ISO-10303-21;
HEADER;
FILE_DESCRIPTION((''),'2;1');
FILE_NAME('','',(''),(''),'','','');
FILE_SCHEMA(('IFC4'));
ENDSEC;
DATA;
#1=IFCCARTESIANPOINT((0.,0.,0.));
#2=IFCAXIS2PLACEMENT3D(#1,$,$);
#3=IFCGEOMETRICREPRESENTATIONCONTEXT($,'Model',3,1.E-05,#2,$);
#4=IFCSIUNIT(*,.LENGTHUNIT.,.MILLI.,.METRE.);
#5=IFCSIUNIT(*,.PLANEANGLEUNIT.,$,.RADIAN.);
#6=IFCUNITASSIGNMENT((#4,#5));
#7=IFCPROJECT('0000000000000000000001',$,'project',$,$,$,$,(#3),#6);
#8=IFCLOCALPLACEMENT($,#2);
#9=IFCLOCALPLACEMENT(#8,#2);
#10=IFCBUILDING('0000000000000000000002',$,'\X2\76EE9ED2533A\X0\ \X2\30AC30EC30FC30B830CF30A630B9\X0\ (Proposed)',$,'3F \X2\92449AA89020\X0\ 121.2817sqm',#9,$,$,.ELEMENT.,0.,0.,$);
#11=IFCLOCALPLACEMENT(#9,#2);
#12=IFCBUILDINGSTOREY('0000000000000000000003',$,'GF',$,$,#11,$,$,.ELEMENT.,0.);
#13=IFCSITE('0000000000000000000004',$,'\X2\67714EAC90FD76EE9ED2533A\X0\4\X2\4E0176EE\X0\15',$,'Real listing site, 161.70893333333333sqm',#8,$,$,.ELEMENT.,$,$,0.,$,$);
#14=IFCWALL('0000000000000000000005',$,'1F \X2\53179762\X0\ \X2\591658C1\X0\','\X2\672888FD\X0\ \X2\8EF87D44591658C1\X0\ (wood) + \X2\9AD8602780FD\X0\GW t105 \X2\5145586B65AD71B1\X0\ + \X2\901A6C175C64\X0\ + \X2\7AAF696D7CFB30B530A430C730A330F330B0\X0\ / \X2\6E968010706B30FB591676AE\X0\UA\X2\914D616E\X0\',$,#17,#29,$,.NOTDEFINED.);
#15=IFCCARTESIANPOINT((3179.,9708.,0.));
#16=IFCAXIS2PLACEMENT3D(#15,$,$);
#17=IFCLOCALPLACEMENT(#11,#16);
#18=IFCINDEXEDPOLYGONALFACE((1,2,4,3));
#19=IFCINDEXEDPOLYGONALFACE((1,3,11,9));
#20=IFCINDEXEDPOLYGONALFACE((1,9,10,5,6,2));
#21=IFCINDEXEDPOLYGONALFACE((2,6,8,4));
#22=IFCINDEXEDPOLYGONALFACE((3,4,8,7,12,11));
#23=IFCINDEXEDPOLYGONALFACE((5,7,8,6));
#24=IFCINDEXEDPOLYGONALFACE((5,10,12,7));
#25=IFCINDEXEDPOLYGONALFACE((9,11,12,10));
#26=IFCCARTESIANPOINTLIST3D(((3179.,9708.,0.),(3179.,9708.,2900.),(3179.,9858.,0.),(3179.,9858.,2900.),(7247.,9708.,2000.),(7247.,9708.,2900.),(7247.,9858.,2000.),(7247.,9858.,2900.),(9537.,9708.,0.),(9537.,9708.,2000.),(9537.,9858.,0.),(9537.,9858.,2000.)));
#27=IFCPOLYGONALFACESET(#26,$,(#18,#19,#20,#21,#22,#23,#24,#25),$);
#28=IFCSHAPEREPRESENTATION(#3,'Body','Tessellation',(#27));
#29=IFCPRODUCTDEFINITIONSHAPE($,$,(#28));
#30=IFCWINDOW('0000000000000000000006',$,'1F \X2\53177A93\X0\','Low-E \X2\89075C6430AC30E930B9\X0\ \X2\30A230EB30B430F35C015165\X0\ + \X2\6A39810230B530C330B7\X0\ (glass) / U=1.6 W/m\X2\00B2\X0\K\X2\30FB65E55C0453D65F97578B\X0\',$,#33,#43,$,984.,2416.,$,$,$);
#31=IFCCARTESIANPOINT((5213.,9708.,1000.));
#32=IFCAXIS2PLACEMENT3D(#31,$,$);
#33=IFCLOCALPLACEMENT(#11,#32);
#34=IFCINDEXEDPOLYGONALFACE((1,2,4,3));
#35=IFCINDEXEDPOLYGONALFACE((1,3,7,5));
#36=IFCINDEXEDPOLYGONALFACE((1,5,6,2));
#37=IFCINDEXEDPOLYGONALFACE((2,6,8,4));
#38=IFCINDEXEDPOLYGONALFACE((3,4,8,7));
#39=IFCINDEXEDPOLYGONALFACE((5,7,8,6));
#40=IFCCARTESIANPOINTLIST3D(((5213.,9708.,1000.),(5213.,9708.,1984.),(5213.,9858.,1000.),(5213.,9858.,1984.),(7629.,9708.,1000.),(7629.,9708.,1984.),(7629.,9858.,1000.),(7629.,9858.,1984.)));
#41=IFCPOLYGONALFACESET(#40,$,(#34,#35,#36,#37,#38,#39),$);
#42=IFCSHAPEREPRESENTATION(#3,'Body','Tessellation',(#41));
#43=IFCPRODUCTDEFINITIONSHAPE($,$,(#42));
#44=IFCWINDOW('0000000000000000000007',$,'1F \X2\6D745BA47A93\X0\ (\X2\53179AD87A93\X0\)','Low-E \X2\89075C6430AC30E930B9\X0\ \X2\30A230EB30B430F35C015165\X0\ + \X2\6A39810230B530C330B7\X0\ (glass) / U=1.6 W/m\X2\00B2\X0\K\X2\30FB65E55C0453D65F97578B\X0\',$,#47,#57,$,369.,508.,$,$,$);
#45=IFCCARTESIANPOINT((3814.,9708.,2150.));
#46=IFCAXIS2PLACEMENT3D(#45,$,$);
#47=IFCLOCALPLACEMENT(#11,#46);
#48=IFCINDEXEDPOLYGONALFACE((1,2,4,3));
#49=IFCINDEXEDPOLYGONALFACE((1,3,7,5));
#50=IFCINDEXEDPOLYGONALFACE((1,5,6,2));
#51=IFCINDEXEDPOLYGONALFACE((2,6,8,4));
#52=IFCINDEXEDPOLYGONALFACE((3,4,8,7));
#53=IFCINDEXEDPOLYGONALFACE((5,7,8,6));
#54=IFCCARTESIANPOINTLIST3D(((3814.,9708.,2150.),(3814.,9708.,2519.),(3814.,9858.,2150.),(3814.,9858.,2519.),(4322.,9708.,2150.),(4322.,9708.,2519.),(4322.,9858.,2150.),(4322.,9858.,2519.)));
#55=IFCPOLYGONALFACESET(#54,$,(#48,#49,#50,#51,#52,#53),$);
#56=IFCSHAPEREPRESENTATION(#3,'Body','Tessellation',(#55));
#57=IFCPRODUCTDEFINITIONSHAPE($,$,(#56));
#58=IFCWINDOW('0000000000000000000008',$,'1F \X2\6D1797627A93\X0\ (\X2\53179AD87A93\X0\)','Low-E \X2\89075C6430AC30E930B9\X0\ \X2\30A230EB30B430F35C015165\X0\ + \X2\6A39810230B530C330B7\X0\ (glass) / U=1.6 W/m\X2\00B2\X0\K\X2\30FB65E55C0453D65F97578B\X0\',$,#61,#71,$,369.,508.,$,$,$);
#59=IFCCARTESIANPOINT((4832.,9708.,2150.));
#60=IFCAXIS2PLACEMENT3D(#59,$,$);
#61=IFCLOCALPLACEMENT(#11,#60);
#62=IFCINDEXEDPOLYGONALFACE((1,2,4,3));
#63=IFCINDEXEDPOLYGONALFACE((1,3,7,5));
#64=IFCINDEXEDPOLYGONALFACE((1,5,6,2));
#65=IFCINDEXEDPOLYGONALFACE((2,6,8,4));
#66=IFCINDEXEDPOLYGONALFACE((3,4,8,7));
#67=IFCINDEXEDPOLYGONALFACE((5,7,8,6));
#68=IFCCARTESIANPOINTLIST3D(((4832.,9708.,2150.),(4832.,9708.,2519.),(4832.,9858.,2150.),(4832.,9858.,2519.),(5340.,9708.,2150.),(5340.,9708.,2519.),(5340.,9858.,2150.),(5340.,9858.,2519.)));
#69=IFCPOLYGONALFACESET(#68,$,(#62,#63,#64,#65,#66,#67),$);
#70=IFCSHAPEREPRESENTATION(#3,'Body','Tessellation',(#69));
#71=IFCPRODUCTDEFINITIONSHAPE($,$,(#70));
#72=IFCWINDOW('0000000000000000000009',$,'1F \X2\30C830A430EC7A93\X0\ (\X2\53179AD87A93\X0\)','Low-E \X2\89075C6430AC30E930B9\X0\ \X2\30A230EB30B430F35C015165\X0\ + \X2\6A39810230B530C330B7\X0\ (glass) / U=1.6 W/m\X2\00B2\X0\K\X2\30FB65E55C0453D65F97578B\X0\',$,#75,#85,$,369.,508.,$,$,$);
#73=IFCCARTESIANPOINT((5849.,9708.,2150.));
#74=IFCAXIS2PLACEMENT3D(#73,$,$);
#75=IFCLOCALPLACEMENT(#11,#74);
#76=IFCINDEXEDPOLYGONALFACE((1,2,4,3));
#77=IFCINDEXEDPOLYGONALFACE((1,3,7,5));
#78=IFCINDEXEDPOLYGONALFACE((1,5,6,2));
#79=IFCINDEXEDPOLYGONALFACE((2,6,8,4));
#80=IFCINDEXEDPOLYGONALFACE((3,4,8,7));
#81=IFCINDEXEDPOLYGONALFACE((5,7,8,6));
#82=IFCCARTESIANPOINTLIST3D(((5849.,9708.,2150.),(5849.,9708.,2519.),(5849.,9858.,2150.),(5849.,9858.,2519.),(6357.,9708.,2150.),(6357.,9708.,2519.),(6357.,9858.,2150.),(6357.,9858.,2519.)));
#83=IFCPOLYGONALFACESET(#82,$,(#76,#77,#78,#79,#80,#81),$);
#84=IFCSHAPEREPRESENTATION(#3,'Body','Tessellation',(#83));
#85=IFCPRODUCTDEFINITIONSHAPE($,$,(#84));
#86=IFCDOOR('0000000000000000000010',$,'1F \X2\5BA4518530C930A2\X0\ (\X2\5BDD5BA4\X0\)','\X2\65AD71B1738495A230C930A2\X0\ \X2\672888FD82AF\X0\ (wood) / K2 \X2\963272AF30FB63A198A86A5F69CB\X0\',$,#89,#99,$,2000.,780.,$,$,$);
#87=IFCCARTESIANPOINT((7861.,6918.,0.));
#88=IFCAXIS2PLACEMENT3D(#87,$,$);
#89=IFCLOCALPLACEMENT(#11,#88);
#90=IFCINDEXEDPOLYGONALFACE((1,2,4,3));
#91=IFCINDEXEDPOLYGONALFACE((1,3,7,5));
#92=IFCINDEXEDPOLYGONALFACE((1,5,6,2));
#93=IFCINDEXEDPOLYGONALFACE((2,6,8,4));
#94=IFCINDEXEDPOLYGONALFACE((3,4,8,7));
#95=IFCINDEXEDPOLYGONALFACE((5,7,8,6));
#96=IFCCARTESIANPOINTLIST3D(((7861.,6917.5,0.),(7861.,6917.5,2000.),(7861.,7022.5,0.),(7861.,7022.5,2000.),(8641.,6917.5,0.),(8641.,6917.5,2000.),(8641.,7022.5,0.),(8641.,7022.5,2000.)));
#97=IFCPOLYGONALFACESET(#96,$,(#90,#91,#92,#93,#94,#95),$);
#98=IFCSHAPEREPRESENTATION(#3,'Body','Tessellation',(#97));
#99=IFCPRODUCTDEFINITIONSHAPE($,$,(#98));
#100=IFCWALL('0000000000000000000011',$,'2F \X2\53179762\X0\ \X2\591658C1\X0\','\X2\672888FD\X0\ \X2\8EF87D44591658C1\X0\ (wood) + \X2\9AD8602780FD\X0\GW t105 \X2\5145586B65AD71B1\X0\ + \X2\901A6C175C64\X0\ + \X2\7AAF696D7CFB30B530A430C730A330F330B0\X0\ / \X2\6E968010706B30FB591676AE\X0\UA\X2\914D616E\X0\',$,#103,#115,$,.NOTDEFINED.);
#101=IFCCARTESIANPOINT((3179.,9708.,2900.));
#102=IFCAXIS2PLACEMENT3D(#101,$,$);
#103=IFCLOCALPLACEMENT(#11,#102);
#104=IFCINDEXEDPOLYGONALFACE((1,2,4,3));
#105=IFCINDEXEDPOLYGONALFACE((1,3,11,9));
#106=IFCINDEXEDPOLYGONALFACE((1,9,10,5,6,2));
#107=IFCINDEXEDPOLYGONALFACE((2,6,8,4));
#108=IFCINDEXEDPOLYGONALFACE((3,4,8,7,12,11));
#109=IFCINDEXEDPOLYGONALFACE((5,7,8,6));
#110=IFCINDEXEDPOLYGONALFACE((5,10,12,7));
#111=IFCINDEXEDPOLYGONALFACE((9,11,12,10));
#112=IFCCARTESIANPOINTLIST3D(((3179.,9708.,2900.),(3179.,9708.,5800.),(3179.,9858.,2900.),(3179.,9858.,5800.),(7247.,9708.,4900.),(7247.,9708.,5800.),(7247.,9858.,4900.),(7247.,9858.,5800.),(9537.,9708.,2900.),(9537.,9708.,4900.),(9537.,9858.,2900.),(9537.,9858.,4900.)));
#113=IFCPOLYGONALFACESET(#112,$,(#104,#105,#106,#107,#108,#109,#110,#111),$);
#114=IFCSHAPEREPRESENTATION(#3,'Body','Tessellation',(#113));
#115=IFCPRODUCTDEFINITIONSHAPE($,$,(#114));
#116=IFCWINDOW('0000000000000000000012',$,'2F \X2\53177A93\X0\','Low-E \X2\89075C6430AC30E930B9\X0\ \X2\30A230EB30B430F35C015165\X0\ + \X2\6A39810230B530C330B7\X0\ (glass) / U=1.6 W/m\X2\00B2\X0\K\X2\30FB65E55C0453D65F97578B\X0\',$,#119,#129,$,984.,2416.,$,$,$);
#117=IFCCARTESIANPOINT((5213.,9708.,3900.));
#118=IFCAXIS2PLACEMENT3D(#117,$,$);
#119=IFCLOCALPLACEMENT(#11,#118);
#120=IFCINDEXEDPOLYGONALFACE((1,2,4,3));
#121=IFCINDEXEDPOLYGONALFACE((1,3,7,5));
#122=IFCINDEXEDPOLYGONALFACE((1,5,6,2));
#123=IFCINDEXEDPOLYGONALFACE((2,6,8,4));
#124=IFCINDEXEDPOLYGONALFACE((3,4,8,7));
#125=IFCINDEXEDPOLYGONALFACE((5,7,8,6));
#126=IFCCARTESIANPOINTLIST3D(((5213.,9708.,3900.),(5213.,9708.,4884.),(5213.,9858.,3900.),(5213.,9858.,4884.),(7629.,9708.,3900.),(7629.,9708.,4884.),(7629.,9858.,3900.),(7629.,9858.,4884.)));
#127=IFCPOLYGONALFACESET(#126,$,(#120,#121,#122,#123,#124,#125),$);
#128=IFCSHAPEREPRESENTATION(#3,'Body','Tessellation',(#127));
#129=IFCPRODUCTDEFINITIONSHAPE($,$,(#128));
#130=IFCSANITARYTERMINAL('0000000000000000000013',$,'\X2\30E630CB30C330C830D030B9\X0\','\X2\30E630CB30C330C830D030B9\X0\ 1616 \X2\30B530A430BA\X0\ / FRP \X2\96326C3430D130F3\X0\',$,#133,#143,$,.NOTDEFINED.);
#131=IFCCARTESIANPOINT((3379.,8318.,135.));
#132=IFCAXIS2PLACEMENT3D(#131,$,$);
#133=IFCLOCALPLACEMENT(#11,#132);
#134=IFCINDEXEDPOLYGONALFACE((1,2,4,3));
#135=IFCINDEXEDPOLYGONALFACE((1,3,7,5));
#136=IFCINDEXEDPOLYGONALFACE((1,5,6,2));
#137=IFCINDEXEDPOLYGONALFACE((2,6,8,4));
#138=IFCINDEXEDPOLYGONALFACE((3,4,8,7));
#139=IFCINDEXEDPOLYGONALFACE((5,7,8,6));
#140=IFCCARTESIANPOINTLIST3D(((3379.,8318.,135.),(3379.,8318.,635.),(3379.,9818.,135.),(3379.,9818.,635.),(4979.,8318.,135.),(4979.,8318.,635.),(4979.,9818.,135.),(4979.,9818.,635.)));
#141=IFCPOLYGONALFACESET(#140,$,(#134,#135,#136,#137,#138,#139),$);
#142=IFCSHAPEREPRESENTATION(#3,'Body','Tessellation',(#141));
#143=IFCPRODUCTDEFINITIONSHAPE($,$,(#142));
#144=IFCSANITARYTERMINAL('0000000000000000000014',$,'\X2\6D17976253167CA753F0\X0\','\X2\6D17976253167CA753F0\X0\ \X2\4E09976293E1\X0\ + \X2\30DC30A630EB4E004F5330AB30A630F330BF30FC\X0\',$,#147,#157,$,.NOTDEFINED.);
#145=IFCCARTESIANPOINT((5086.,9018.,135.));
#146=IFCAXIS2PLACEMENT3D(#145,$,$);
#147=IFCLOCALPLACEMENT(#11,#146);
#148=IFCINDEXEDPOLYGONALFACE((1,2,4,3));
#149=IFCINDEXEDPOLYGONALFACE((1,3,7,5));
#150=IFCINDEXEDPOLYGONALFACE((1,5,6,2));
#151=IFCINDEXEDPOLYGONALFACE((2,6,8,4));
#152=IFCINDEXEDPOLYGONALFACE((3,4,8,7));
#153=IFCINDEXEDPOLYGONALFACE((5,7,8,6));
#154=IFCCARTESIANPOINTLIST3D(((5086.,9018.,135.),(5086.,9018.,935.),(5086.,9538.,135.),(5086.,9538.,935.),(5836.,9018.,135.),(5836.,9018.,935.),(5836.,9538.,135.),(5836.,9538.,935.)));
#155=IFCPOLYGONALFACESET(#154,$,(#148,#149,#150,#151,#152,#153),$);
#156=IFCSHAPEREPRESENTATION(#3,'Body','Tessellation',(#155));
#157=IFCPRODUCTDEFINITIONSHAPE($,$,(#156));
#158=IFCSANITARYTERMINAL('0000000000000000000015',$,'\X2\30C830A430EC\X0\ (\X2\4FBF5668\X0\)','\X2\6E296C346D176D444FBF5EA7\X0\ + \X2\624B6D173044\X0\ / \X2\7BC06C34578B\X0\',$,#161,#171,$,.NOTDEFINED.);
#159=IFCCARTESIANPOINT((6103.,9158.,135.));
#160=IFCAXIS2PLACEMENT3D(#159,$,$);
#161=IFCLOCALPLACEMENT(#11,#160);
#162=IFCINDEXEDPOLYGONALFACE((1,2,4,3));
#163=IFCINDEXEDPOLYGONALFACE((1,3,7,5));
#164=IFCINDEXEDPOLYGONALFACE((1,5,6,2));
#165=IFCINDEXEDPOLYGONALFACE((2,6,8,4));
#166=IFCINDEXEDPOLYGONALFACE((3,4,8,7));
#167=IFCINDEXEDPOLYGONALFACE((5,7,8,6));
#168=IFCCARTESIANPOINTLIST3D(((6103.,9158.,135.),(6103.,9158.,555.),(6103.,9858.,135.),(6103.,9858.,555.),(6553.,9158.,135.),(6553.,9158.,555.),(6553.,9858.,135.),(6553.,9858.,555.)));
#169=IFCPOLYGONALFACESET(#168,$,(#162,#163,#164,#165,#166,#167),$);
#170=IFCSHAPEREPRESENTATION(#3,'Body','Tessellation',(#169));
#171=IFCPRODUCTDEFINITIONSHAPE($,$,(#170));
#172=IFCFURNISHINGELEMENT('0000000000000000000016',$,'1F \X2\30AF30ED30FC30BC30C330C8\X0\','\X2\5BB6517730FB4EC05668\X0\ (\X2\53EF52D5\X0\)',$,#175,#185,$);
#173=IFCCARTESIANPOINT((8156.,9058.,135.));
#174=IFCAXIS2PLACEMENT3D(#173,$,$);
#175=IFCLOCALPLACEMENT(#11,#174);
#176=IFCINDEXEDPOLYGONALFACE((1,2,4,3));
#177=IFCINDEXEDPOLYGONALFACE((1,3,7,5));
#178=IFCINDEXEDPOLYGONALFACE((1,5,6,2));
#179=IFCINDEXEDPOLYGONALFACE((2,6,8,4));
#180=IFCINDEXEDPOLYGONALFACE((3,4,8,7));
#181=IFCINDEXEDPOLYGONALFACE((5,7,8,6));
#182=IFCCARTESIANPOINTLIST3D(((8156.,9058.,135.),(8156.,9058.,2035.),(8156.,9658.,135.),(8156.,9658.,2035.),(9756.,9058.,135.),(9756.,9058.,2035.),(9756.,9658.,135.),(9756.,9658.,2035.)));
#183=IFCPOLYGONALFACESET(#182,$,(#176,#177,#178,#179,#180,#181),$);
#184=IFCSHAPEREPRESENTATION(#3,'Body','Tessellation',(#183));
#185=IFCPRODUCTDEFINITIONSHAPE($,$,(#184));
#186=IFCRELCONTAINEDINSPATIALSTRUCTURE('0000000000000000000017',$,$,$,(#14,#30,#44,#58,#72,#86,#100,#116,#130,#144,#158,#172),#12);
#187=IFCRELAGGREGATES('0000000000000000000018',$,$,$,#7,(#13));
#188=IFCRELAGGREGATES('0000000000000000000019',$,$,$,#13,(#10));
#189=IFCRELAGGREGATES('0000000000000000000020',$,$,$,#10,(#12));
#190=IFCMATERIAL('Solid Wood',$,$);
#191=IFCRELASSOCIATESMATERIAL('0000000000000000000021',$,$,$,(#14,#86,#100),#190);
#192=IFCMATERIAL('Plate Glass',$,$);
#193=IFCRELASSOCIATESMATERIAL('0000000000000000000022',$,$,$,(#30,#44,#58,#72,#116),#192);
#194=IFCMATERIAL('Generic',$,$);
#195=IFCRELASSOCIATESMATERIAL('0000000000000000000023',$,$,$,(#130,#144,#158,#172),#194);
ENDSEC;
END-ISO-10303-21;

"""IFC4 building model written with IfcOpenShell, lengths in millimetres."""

from ifc_helpers import new_model, si_unit, frame, frame_2d, origin, place, context, project, spatial, rectangle, extrude, material, element, fill, save


model = new_model("IFC4")

# Units and contexts
model_context = context("Model", 3, precision=1e-05, world=origin())
ifc_project = project(units=[si_unit("LENGTHUNIT", "METRE", prefix="MILLI"), si_unit("PLANEANGLEUNIT", "RADIAN")], contexts=[model_context])

# Site, building, storey
site_placement = place(None, origin())
site = spatial("IfcSite", under=ifc_project, at=site_placement, Name="東京都目黒区4丁目15", ObjectType="Real listing site, 161.70893333333333sqm", CompositionType="ELEMENT", RefElevation=0.0)
building_placement = place(site_placement, origin())
building = spatial("IfcBuilding", under=site, at=building_placement, Name="目黒区 ガレージハウス (Proposed)", ObjectType="3F 鉄骨造 121.2817sqm", CompositionType="ELEMENT", ElevationOfRefHeight=0.0, ElevationOfTerrain=0.0)
storey_placement = place(building_placement, origin())
storey = spatial("IfcBuildingStorey", under=building, at=storey_placement, Name="GF", CompositionType="ELEMENT", Elevation=0.0)

# Wall, openings, windows
ifc_material_1 = material(Name="Solid Wood")
wall_1_placement = place(storey_placement, frame((3179.0, 9708.0, 0.0)))
wall_1 = element("IfcWall", 1, at=wall_1_placement, inside=storey, material=ifc_material_1, Name="1F 北面 外壁", Description="木製 軸組外壁 (wood) + 高性能GW t105 充填断熱 + 通気層 + 窯業系サイディング / 準耐火・外皮UA配慮", PredefinedType="NOTDEFINED", context=model_context, shape_type="SweptSolid", body=[
    extrude(rectangle(XDim=6358.0, YDim=150.0, at=frame_2d((3179.0, 75.0))), frame((3179.0, 9708.0, 0.0)), (0.0, 0.0, 1.0), 2900.0),
])
opening_1_placement = place(storey_placement, frame((5213.0, 9708.0, 1000.0)))
opening_1 = element("IfcOpeningElement", 2, at=opening_1_placement, cuts=wall_1, PredefinedType="NOTDEFINED", context=model_context, shape_type="SweptSolid", body=[
    extrude(rectangle(XDim=2416.0, YDim=150.0, at=frame_2d((1208.0, 75.0))), frame((5213.0, 9708.0, 1000.0)), (0.0, 0.0, 1.0), 984.0),
])
opening_2_placement = place(storey_placement, frame((3814.0, 9708.0, 2150.0)))
opening_2 = element("IfcOpeningElement", 3, at=opening_2_placement, cuts=wall_1, PredefinedType="NOTDEFINED", context=model_context, shape_type="SweptSolid", body=[
    extrude(rectangle(XDim=508.0, YDim=150.0, at=frame_2d((254.0, 75.0))), frame((3814.0, 9708.0, 2150.0)), (0.0, 0.0, 1.0), 369.0),
])
opening_3_placement = place(storey_placement, frame((4832.0, 9708.0, 2150.0)))
opening_3 = element("IfcOpeningElement", 4, at=opening_3_placement, cuts=wall_1, PredefinedType="NOTDEFINED", context=model_context, shape_type="SweptSolid", body=[
    extrude(rectangle(XDim=508.0, YDim=150.0, at=frame_2d((254.0, 75.0))), frame((4832.0, 9708.0, 2150.0)), (0.0, 0.0, 1.0), 369.0),
])
opening_4_placement = place(storey_placement, frame((5849.0, 9708.0, 2150.0)))
opening_4 = element("IfcOpeningElement", 5, at=opening_4_placement, cuts=wall_1, PredefinedType="NOTDEFINED", context=model_context, shape_type="SweptSolid", body=[
    extrude(rectangle(XDim=508.0, YDim=150.0, at=frame_2d((254.0, 75.0))), frame((5849.0, 9708.0, 2150.0)), (0.0, 0.0, 1.0), 369.0),
])
ifc_material_2 = material(Name="Plate Glass")
window_1_placement = place(storey_placement, frame((5213.0, 9708.0, 1000.0)))
window_1 = element("IfcWindow", 6, at=window_1_placement, inside=storey, material=ifc_material_2, Name="1F 北窓", Description="Low-E 複層ガラス アルゴン封入 + 樹脂サッシ (glass) / U=1.6 W/m²K・日射取得型", OverallHeight=984.0, OverallWidth=2416.0, context=model_context, shape_type="SweptSolid", body=[
    extrude(rectangle(XDim=2416.0, YDim=150.0, at=frame_2d((1208.0, 75.0))), frame((5213.0, 9708.0, 1000.0)), (0.0, 0.0, 1.0), 984.0),
])
fill(opening_1, window_1)
window_2_placement = place(storey_placement, frame((3814.0, 9708.0, 2150.0)))
window_2 = element("IfcWindow", 7, at=window_2_placement, inside=storey, material=ifc_material_2, Name="1F 浴室窓 (北高窓)", Description="Low-E 複層ガラス アルゴン封入 + 樹脂サッシ (glass) / U=1.6 W/m²K・日射取得型", OverallHeight=369.0, OverallWidth=508.0, context=model_context, shape_type="SweptSolid", body=[
    extrude(rectangle(XDim=508.0, YDim=150.0, at=frame_2d((254.0, 75.0))), frame((3814.0, 9708.0, 2150.0)), (0.0, 0.0, 1.0), 369.0),
])
fill(opening_2, window_2)
window_3_placement = place(storey_placement, frame((4832.0, 9708.0, 2150.0)))
window_3 = element("IfcWindow", 8, at=window_3_placement, inside=storey, material=ifc_material_2, Name="1F 洗面窓 (北高窓)", Description="Low-E 複層ガラス アルゴン封入 + 樹脂サッシ (glass) / U=1.6 W/m²K・日射取得型", OverallHeight=369.0, OverallWidth=508.0, context=model_context, shape_type="SweptSolid", body=[
    extrude(rectangle(XDim=508.0, YDim=150.0, at=frame_2d((254.0, 75.0))), frame((4832.0, 9708.0, 2150.0)), (0.0, 0.0, 1.0), 369.0),
])
fill(opening_3, window_3)
window_4_placement = place(storey_placement, frame((5849.0, 9708.0, 2150.0)))
window_4 = element("IfcWindow", 9, at=window_4_placement, inside=storey, material=ifc_material_2, Name="1F トイレ窓 (北高窓)", Description="Low-E 複層ガラス アルゴン封入 + 樹脂サッシ (glass) / U=1.6 W/m²K・日射取得型", OverallHeight=369.0, OverallWidth=508.0, context=model_context, shape_type="SweptSolid", body=[
    extrude(rectangle(XDim=508.0, YDim=150.0, at=frame_2d((254.0, 75.0))), frame((5849.0, 9708.0, 2150.0)), (0.0, 0.0, 1.0), 369.0),
])
fill(opening_4, window_4)

# Door
door_1_placement = place(storey_placement, frame((7861.0, 6918.0, 0.0)))
element("IfcDoor", 10, at=door_1_placement, inside=storey, material=ifc_material_1, Name="1F 室内ドア (寝室)", Description="断熱玄関ドア 木製芯 (wood) / K2 防犯・採風機構", OverallHeight=2000.0, OverallWidth=780.0, context=model_context, shape_type="SweptSolid", body=[
    extrude(rectangle(XDim=780.0, YDim=105.0, at=frame_2d((390.0, 52.0))), frame((7861.0, 6918.0, 0.0)), (0.0, 0.0, 1.0), 2000.0),
])

# Wall, opening, window
wall_2_placement = place(storey_placement, frame((3179.0, 9708.0, 2900.0)))
wall_2 = element("IfcWall", 11, at=wall_2_placement, inside=storey, material=ifc_material_1, Name="2F 北面 外壁", Description="木製 軸組外壁 (wood) + 高性能GW t105 充填断熱 + 通気層 + 窯業系サイディング / 準耐火・外皮UA配慮", PredefinedType="NOTDEFINED", context=model_context, shape_type="SweptSolid", body=[
    extrude(rectangle(XDim=6358.0, YDim=150.0, at=frame_2d((3179.0, 75.0))), frame((3179.0, 9708.0, 2900.0)), (0.0, 0.0, 1.0), 2900.0),
])
opening_5_placement = place(storey_placement, frame((5213.0, 9708.0, 3900.0)))
opening_5 = element("IfcOpeningElement", 12, at=opening_5_placement, cuts=wall_2, PredefinedType="NOTDEFINED", context=model_context, shape_type="SweptSolid", body=[
    extrude(rectangle(XDim=2416.0, YDim=150.0, at=frame_2d((1208.0, 75.0))), frame((5213.0, 9708.0, 3900.0)), (0.0, 0.0, 1.0), 984.0),
])
window_5_placement = place(storey_placement, frame((5213.0, 9708.0, 3900.0)))
window_5 = element("IfcWindow", 13, at=window_5_placement, inside=storey, material=ifc_material_2, Name="2F 北窓", Description="Low-E 複層ガラス アルゴン封入 + 樹脂サッシ (glass) / U=1.6 W/m²K・日射取得型", OverallHeight=984.0, OverallWidth=2416.0, context=model_context, shape_type="SweptSolid", body=[
    extrude(rectangle(XDim=2416.0, YDim=150.0, at=frame_2d((1208.0, 75.0))), frame((5213.0, 9708.0, 3900.0)), (0.0, 0.0, 1.0), 984.0),
])
fill(opening_5, window_5)

# Sanitary terminals
ifc_material_3 = material(Name="Generic")
sanitary_terminal_1_placement = place(storey_placement, frame((3379.0, 8318.0, 135.0)))
element("IfcSanitaryTerminal", 14, at=sanitary_terminal_1_placement, inside=storey, material=ifc_material_3, Name="ユニットバス", Description="ユニットバス 1616 サイズ / FRP 防水パン", PredefinedType="NOTDEFINED", context=model_context, shape_type="SweptSolid", body=[
    extrude(rectangle(XDim=1600.0, YDim=1500.0, at=frame_2d((800.0, 750.0))), frame((3379.0, 8318.0, 135.0)), (0.0, 0.0, 1.0), 500.0),
])
sanitary_terminal_2_placement = place(storey_placement, frame((5086.0, 9018.0, 135.0)))
element("IfcSanitaryTerminal", 15, at=sanitary_terminal_2_placement, inside=storey, material=ifc_material_3, Name="洗面化粧台", Description="洗面化粧台 三面鏡 + ボウル一体カウンター", PredefinedType="NOTDEFINED", context=model_context, shape_type="SweptSolid", body=[
    extrude(rectangle(XDim=750.0, YDim=520.0, at=frame_2d((375.0, 260.0))), frame((5086.0, 9018.0, 135.0)), (0.0, 0.0, 1.0), 800.0),
])
sanitary_terminal_3_placement = place(storey_placement, frame((6103.0, 9158.0, 135.0)))
element("IfcSanitaryTerminal", 16, at=sanitary_terminal_3_placement, inside=storey, material=ifc_material_3, Name="トイレ (便器)", Description="温水洗浄便座 + 手洗い / 節水型", PredefinedType="NOTDEFINED", context=model_context, shape_type="SweptSolid", body=[
    extrude(rectangle(XDim=450.0, YDim=700.0, at=frame_2d((225.0, 350.0))), frame((6103.0, 9158.0, 135.0)), (0.0, 0.0, 1.0), 420.0),
])

# Furnishing element
furnishing_1_placement = place(storey_placement, frame((8156.0, 9058.0, 135.0)))
element("IfcFurnishingElement", 17, at=furnishing_1_placement, inside=storey, material=ifc_material_3, Name="1F クローゼット", Description="家具・什器 (可動)", context=model_context, shape_type="SweptSolid", body=[
    extrude(rectangle(XDim=1600.0, YDim=600.0, at=frame_2d((800.0, 300.0))), frame((8156.0, 9058.0, 135.0)), (0.0, 0.0, 1.0), 1900.0),
])

save(model, "model.ifc")
